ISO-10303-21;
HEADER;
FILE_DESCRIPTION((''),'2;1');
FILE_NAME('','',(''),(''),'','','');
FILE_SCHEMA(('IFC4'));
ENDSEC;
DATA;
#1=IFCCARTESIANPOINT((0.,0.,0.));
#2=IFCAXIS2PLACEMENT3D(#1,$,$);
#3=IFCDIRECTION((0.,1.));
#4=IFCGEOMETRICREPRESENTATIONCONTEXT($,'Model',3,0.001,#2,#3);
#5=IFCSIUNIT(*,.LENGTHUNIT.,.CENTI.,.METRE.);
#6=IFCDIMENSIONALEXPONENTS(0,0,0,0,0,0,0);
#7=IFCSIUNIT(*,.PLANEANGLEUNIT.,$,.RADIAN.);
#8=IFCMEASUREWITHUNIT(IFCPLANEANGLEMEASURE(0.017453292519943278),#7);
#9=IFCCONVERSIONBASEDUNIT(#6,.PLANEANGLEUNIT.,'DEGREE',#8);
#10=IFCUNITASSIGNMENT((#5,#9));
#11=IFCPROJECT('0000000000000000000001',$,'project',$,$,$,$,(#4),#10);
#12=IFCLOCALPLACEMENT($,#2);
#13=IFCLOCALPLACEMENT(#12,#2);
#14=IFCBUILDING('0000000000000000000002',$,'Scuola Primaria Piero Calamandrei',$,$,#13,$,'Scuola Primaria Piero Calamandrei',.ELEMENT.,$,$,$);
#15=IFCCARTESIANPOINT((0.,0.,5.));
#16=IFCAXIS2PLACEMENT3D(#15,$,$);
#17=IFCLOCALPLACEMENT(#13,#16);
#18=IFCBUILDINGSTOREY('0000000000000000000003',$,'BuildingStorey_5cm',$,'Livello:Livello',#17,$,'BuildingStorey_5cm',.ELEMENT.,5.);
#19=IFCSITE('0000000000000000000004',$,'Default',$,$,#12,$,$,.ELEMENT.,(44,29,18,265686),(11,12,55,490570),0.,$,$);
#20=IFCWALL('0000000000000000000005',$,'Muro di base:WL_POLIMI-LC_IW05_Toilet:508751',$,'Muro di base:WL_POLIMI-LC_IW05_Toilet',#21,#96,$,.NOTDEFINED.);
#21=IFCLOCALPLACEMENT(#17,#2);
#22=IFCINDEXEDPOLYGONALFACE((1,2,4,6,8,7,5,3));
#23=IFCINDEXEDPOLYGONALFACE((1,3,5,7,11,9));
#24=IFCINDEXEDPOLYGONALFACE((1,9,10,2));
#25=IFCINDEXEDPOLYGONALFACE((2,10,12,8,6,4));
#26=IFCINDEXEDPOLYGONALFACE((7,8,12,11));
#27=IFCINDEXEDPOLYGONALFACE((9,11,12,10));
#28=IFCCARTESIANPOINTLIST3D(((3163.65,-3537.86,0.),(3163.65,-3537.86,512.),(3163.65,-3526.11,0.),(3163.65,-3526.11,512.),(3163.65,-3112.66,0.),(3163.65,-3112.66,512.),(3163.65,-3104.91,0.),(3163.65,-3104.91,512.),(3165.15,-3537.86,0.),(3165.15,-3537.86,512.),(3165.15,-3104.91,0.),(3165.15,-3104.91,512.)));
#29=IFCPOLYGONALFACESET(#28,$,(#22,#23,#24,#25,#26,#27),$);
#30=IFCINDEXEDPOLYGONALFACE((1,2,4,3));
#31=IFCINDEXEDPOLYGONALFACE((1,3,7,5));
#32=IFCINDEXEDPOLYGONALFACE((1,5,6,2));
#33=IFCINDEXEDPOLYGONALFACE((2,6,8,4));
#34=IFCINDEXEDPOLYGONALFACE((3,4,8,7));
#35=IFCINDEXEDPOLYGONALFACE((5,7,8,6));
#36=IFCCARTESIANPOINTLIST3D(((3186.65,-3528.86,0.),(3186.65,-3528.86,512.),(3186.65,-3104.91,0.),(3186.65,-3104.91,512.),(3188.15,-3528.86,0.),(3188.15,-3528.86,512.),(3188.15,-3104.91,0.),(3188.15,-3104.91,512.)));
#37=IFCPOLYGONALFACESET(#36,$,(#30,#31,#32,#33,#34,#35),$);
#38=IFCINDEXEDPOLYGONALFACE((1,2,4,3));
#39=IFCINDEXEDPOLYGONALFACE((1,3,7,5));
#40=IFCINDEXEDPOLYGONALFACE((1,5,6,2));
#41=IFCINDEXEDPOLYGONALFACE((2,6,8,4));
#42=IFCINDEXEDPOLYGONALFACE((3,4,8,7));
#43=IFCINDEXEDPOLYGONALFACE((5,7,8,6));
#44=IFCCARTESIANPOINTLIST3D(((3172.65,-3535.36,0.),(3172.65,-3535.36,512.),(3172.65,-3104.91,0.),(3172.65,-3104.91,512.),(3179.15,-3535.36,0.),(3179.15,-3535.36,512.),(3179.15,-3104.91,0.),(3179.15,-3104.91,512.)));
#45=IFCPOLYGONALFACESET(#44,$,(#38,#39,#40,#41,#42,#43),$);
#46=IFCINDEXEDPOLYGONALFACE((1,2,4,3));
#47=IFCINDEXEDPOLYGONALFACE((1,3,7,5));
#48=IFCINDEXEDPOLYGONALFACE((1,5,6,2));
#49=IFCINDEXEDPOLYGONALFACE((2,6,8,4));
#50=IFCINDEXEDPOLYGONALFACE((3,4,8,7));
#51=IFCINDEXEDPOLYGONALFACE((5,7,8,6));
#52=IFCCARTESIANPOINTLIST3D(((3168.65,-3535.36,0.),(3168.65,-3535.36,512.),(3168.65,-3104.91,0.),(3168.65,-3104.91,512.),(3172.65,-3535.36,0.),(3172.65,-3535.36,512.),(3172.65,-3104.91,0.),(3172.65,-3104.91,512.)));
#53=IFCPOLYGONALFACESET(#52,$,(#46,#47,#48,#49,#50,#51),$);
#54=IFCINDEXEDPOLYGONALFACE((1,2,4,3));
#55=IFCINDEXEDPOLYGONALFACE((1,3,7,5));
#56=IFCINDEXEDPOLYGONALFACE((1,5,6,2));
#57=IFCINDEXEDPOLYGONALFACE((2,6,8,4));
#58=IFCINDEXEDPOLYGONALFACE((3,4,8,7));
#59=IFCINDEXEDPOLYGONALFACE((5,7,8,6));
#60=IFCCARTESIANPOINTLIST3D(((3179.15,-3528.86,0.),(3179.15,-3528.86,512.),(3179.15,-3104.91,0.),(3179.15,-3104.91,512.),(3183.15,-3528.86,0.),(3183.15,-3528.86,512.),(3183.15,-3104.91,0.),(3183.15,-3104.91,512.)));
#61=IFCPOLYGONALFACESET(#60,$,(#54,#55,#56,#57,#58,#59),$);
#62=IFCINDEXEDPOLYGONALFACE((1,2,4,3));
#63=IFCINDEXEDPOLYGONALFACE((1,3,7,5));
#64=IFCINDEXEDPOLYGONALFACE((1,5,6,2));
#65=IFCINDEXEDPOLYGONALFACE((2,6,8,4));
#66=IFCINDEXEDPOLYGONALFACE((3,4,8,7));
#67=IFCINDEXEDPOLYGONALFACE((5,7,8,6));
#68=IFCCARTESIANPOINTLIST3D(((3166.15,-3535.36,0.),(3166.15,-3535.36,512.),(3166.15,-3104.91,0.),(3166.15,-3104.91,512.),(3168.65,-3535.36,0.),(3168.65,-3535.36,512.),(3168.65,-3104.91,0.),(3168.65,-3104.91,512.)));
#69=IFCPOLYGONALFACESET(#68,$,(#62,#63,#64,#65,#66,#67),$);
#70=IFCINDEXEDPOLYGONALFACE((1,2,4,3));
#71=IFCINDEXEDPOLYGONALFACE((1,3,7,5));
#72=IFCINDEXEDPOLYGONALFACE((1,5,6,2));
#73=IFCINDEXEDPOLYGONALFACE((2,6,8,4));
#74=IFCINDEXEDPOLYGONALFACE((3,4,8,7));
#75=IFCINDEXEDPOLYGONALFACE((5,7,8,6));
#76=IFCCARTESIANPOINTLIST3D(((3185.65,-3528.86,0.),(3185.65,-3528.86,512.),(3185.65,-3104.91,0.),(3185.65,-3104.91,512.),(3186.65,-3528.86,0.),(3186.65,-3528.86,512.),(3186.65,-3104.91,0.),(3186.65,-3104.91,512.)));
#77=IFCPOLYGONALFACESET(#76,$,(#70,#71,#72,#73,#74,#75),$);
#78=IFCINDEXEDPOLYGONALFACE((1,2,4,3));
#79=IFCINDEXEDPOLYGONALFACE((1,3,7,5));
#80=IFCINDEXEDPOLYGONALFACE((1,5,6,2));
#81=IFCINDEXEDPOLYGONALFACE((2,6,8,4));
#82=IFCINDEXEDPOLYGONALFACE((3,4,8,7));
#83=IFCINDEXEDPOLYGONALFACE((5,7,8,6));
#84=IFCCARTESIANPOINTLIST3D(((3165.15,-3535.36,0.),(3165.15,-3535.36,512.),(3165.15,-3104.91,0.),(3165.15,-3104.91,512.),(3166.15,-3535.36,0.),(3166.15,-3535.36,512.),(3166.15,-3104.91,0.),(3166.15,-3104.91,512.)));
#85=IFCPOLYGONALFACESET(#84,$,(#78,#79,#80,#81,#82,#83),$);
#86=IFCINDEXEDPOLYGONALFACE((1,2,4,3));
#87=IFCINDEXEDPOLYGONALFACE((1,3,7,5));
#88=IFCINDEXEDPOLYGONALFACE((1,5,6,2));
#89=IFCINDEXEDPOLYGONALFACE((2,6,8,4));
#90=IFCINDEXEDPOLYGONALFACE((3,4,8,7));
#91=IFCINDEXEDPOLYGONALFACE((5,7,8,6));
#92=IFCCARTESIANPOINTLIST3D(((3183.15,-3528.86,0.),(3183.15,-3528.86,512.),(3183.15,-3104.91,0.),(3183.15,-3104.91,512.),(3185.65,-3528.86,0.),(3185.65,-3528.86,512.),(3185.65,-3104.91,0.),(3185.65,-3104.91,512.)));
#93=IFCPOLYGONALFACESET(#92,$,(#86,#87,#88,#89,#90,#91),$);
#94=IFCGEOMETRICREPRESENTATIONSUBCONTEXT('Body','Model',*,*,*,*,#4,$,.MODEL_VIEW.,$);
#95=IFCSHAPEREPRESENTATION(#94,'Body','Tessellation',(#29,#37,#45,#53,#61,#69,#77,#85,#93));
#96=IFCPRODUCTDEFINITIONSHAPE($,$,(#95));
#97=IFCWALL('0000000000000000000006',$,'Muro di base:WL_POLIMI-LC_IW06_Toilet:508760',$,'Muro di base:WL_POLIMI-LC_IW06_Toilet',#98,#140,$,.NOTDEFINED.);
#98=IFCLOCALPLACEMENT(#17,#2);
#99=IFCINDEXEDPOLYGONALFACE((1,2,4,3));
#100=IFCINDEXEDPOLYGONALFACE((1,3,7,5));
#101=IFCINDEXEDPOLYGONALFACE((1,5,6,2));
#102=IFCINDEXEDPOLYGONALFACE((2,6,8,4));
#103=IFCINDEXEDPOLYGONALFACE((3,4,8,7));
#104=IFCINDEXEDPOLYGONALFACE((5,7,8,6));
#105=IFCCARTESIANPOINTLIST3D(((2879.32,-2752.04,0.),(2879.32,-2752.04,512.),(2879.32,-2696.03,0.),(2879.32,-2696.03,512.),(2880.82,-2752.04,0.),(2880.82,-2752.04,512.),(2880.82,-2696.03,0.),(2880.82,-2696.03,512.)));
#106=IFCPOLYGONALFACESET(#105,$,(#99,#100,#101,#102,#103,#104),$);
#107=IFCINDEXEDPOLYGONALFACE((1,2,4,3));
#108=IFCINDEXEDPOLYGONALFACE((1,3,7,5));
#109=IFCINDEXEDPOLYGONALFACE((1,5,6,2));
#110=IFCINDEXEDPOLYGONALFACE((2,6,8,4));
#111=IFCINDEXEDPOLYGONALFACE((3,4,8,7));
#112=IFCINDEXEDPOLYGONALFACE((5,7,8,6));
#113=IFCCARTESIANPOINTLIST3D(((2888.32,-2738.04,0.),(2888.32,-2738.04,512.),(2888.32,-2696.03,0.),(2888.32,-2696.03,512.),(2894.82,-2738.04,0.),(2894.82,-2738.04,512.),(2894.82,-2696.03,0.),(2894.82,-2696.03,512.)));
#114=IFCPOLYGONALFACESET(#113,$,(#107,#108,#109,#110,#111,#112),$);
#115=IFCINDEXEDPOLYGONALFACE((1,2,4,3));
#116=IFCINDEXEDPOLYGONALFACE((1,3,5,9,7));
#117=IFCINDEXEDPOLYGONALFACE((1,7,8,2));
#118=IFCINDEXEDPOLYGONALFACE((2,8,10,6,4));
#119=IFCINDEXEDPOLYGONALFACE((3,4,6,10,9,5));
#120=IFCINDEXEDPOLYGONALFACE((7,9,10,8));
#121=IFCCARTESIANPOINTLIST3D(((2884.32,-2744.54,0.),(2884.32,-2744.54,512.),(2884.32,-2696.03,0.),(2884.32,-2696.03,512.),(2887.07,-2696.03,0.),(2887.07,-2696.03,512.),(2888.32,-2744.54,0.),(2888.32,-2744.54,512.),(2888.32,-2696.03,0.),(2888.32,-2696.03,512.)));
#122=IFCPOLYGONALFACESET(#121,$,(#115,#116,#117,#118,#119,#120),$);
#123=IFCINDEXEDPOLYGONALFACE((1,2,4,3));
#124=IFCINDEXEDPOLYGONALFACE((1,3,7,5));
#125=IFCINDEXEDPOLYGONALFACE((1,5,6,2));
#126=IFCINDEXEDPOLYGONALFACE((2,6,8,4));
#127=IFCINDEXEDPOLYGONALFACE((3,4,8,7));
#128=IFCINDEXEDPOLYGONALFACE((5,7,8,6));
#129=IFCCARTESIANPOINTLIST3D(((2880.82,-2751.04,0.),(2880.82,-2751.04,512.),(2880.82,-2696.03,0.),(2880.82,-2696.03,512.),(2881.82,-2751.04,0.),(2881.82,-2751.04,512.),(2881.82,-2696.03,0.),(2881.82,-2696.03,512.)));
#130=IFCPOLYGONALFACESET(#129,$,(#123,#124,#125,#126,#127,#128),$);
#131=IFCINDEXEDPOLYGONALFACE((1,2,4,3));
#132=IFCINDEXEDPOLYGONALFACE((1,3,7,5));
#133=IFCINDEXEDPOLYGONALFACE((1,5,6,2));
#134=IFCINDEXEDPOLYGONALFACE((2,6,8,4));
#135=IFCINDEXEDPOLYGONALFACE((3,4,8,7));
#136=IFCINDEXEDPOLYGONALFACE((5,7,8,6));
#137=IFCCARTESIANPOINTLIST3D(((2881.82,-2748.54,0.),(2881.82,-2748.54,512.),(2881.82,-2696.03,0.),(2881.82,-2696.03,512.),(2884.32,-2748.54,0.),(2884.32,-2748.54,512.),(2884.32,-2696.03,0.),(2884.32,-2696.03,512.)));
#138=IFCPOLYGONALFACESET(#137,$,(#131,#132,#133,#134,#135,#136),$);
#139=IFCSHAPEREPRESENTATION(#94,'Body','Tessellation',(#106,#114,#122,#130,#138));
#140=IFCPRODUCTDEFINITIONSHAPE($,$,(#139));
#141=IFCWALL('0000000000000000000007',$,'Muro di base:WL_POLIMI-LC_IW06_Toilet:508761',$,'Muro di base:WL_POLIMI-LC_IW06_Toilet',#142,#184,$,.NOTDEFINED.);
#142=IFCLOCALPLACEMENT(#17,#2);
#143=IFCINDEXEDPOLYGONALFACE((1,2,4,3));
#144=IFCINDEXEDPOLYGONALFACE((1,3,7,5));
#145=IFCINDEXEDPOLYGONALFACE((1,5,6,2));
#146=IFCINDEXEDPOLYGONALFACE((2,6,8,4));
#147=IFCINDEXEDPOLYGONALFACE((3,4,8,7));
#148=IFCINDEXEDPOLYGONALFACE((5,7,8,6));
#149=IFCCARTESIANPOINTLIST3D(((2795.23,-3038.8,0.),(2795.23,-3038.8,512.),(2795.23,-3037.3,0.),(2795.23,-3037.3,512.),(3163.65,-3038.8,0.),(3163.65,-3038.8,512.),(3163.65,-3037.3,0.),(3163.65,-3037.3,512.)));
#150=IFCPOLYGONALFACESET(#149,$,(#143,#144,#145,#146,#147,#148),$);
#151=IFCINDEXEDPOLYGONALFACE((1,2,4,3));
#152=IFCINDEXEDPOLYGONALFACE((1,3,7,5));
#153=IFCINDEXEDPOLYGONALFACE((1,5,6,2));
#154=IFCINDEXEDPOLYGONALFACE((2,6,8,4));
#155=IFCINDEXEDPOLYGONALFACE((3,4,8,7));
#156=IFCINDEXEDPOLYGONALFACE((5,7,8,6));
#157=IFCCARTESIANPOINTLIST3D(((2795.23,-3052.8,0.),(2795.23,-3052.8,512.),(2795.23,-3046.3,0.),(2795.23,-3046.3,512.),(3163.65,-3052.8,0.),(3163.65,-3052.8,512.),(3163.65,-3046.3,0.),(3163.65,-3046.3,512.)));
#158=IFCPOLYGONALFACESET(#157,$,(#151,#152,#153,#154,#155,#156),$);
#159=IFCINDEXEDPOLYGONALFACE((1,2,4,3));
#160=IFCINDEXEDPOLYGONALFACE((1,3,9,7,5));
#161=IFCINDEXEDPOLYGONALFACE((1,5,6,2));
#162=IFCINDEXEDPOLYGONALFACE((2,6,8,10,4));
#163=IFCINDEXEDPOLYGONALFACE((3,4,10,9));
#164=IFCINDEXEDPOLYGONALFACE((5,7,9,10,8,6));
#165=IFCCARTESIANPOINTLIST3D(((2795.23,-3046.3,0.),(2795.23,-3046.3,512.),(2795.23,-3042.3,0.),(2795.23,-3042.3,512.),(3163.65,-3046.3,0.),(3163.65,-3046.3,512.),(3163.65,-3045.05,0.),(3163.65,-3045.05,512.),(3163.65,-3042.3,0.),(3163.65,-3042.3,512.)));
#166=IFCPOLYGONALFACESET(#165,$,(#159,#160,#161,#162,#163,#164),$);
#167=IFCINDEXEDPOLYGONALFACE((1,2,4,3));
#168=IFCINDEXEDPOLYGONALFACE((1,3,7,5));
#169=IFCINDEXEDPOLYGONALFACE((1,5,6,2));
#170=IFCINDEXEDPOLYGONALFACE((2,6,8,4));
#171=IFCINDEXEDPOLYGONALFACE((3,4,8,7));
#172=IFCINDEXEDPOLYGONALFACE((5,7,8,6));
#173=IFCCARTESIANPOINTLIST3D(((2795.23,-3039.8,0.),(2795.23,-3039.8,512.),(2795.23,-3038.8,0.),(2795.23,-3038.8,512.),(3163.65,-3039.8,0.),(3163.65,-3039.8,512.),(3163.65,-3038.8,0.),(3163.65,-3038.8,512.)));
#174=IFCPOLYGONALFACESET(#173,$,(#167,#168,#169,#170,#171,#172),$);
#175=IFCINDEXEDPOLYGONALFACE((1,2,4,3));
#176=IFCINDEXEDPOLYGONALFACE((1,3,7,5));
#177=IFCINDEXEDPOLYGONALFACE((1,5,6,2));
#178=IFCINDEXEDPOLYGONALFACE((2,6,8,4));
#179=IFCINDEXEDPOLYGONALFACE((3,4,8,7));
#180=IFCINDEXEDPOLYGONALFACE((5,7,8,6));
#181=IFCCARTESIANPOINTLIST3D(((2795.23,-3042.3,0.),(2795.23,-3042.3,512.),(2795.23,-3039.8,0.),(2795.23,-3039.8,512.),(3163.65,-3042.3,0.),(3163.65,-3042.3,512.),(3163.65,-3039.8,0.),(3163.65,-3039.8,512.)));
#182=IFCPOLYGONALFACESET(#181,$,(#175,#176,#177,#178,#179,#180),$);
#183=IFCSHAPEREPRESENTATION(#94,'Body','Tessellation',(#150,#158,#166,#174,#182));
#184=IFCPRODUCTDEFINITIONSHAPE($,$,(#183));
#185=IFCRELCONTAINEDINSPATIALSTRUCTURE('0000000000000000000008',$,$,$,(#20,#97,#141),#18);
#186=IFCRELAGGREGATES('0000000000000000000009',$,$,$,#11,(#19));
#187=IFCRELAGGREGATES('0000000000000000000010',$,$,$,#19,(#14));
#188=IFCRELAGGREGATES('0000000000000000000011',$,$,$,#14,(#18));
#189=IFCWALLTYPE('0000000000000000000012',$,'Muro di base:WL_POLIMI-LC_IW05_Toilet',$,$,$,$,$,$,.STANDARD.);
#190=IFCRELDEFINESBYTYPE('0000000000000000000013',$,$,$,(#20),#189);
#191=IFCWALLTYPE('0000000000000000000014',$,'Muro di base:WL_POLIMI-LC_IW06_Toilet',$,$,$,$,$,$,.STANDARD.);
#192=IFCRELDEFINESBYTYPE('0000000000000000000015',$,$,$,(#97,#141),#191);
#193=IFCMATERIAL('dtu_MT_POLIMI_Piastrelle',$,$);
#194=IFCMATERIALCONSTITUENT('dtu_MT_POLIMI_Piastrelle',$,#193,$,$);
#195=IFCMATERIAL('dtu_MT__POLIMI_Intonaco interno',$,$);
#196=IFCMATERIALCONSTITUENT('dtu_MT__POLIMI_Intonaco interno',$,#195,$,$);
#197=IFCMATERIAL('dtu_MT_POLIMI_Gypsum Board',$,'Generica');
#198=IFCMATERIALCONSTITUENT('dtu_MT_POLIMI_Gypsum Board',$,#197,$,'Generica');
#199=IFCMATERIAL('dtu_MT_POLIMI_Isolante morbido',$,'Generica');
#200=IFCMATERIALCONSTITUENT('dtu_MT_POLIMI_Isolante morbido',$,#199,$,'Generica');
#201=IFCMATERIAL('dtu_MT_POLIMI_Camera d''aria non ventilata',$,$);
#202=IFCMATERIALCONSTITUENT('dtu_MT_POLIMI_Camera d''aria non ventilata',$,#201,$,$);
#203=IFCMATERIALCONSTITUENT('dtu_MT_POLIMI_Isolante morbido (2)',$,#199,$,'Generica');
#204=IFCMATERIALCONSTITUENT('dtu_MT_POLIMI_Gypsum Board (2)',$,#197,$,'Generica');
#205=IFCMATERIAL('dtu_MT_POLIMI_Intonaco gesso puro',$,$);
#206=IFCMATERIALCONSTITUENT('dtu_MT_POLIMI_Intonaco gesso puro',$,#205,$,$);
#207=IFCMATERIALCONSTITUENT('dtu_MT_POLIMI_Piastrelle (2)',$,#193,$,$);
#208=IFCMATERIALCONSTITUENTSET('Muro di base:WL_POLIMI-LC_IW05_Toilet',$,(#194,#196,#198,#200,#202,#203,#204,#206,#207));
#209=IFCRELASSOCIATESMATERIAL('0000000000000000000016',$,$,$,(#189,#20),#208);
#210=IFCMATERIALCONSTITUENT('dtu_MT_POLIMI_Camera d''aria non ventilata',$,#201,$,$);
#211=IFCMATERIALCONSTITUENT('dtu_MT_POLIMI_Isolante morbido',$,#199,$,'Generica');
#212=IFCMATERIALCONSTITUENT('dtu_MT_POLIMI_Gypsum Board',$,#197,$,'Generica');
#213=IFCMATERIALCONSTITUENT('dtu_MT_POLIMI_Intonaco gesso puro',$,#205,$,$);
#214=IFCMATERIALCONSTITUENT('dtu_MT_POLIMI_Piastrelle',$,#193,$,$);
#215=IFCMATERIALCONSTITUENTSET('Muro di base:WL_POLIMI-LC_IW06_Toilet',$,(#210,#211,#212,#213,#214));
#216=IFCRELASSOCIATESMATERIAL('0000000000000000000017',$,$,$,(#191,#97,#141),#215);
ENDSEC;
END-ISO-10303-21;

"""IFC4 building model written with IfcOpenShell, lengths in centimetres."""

from ifc_helpers import new_model, entity, si_unit, converted_unit, direction, frame, origin, place, context, subcontext, project, spatial, indexed_curve, outline, extrude, material, constituent, constituent_set, type_object, element, save


model = new_model("IFC4")

# Units and contexts
model_context = context("Model", 3, precision=0.001, world=origin(), true_north=direction((0.0, 1.0)))
body_context = subcontext(model_context, "Body", "Model", "MODEL_VIEW")
ifc_project = project(units=[si_unit("LENGTHUNIT", "METRE", prefix="CENTI"), converted_unit("PLANEANGLEUNIT", "DEGREE", entity("IfcPlaneAngleMeasure", 0.017453292519943278), si_unit("PLANEANGLEUNIT", "RADIAN"), dimensions=[0, 0, 0, 0, 0, 0, 0])], contexts=[model_context])

# Site, building, storey
site_placement = place(None, origin())
site = spatial("IfcSite", under=ifc_project, at=site_placement, Name="Default", CompositionType="ELEMENT", RefLatitude=(44, 29, 18, 265686), RefLongitude=(11, 12, 55, 490570), RefElevation=0.0)
building_placement = place(site_placement, origin())
building = spatial("IfcBuilding", under=site, at=building_placement, Name="Scuola Primaria Piero Calamandrei", LongName="Scuola Primaria Piero Calamandrei", CompositionType="ELEMENT")
storey_placement = place(building_placement, frame((0.0, 0.0, 5.0)))
storey = spatial("IfcBuildingStorey", under=building, at=storey_placement, Name="BuildingStorey_5cm", ObjectType="Livello:Livello", LongName="BuildingStorey_5cm", CompositionType="ELEMENT", Elevation=5.0)

# Shared definitions
ifc_material_1 = material(Name="dtu_MT_POLIMI_Intonaco gesso puro")

# Shared definitions
ifc_material_2 = material(Name="dtu_MT_POLIMI_Isolante morbido", Category="Generica")
ifc_material_3 = material(Name="dtu_MT_POLIMI_Gypsum Board", Category="Generica")
ifc_material_4 = material(Name="dtu_MT__POLIMI_Intonaco interno")
ifc_material_5 = material(Name="dtu_MT_POLIMI_Camera d'aria non ventilata")

# Walls
ifc_material_6 = material(Name="dtu_MT_POLIMI_Piastrelle")
ifc_constituent_1 = constituent(ifc_material_6, Name="dtu_MT_POLIMI_Piastrelle")
ifc_constituent_2 = constituent(ifc_material_4, Name="dtu_MT__POLIMI_Intonaco interno")
ifc_constituent_3 = constituent(ifc_material_3, Name="dtu_MT_POLIMI_Gypsum Board", Category="Generica")
ifc_constituent_4 = constituent(ifc_material_2, Name="dtu_MT_POLIMI_Isolante morbido", Category="Generica")
ifc_constituent_5 = constituent(ifc_material_5, Name="dtu_MT_POLIMI_Camera d'aria non ventilata")
ifc_constituent_6 = constituent(ifc_material_2, Name="dtu_MT_POLIMI_Isolante morbido (2)", Category="Generica")
ifc_constituent_7 = constituent(ifc_material_3, Name="dtu_MT_POLIMI_Gypsum Board (2)", Category="Generica")
ifc_constituent_8 = constituent(ifc_material_1, Name="dtu_MT_POLIMI_Intonaco gesso puro")
ifc_constituent_9 = constituent(ifc_material_6, Name="dtu_MT_POLIMI_Piastrelle (2)")
ifc_constituent_set_1 = constituent_set(constituents=[ifc_constituent_1, ifc_constituent_2, ifc_constituent_3, ifc_constituent_4, ifc_constituent_5, ifc_constituent_6, ifc_constituent_7, ifc_constituent_8, ifc_constituent_9], Name="Muro di base:WL_POLIMI-LC_IW05_Toilet")
wall_type_1 = type_object("IfcWallType", Name="Muro di base:WL_POLIMI-LC_IW05_Toilet", PredefinedType="STANDARD", material=ifc_constituent_set_1)
wall_1_placement = place(storey_placement, frame((3175.9, -3528.86, 0.0), z_axis=(0.0, 0.0, 1.0), x_axis=(0.0, 1.0, 0.0)))
element("IfcWall", 1, at=wall_1_placement, inside=storey, type_object=wall_type_1, material=ifc_constituent_set_1, Name="Muro di base:WL_POLIMI-LC_IW05_Toilet:508751", ObjectType="Muro di base:WL_POLIMI-LC_IW05_Toilet", PredefinedType="NOTDEFINED", context=body_context, shape_type="SweptSolid", body=[
    extrude(outline(indexed_curve([(-208.06, -0.5), (205.39, -0.5), (217.14, -0.5), (217.14, 1.0), (-215.81, 1.0), (-215.81, -0.5), (-208.06, -0.5)], self_intersect=False)), frame((208.14, 11.75, 0.0), z_axis=(0.0, 0.0, 1.0), x_axis=(-1.0, 0.0, 0.0)), (0.0, 0.0, 1.0), 512.0),
    extrude(outline(indexed_curve([(-0.75, -211.97), (0.75, -211.97), (0.75, 211.97), (-0.75, 211.97), (-0.75, -211.97)], self_intersect=False)), frame((211.97, -11.5, 0.0), z_axis=(0.0, 0.0, 1.0), x_axis=(0.0, 1.0, 0.0)), (0.0, 0.0, 1.0), 512.0),
    extrude(outline(indexed_curve([(-215.22, -3.25), (215.22, -3.25), (215.22, 3.25), (-215.22, 3.25), (-215.22, -3.25)], self_intersect=False)), frame((208.72, 0.0, 0.0)), (0.0, 0.0, 1.0), 512.0),
    extrude(outline(indexed_curve([(-215.22, -2.0), (215.22, -2.0), (215.22, 2.0), (-215.22, 2.0), (-215.22, -2.0)], self_intersect=False)), frame((208.72, 5.25, 0.0)), (0.0, 0.0, 1.0), 512.0),
    extrude(outline(indexed_curve([(-211.97, -2.0), (211.97, -2.0), (211.97, 2.0), (-211.97, 2.0), (-211.97, -2.0)], self_intersect=False)), frame((211.97, -5.25, 0.0)), (0.0, 0.0, 1.0), 512.0),
    extrude(outline(indexed_curve([(-215.22, -1.25), (215.22, -1.25), (215.22, 1.25), (-215.22, 1.25), (-215.22, -1.25)], self_intersect=False)), frame((208.72, 8.5, 0.0)), (0.0, 0.0, 1.0), 512.0),
    extrude(outline(indexed_curve([(-211.97, -0.5), (211.97, -0.5), (211.97, 0.5), (-211.97, 0.5), (-211.97, -0.5)], self_intersect=False)), frame((211.97, -10.25, 0.0)), (0.0, 0.0, 1.0), 512.0),
    extrude(outline(indexed_curve([(-215.22, -0.5), (215.22, -0.5), (215.22, 0.5), (-215.22, 0.5), (-215.22, -0.5)], self_intersect=False)), frame((208.72, 10.25, 0.0)), (0.0, 0.0, 1.0), 512.0),
    extrude(outline(indexed_curve([(-211.97, -1.25), (211.97, -1.25), (211.97, 1.25), (-211.97, 1.25), (-211.97, -1.25)], self_intersect=False)), frame((211.97, -8.5, 0.0)), (0.0, 0.0, 1.0), 512.0),
])
ifc_constituent_10 = constituent(ifc_material_5, Name="dtu_MT_POLIMI_Camera d'aria non ventilata")
ifc_constituent_11 = constituent(ifc_material_2, Name="dtu_MT_POLIMI_Isolante morbido", Category="Generica")
ifc_constituent_12 = constituent(ifc_material_3, Name="dtu_MT_POLIMI_Gypsum Board", Category="Generica")
ifc_constituent_13 = constituent(ifc_material_1, Name="dtu_MT_POLIMI_Intonaco gesso puro")
ifc_constituent_14 = constituent(ifc_material_6, Name="dtu_MT_POLIMI_Piastrelle")
ifc_constituent_set_2 = constituent_set(constituents=[ifc_constituent_10, ifc_constituent_11, ifc_constituent_12, ifc_constituent_13, ifc_constituent_14], Name="Muro di base:WL_POLIMI-LC_IW06_Toilet")
wall_type_2 = type_object("IfcWallType", Name="Muro di base:WL_POLIMI-LC_IW06_Toilet", PredefinedType="STANDARD", material=ifc_constituent_set_2)
wall_2_placement = place(storey_placement, frame((2887.07, -2696.03, 0.0), z_axis=(0.0, 0.0, 1.0), x_axis=(0.0, -1.0, 0.0)))
element("IfcWall", 2, at=wall_2_placement, inside=storey, type_object=wall_type_2, material=ifc_constituent_set_2, Name="Muro di base:WL_POLIMI-LC_IW06_Toilet:508760", ObjectType="Muro di base:WL_POLIMI-LC_IW06_Toilet", PredefinedType="NOTDEFINED", context=body_context, shape_type="SweptSolid", body=[
    extrude(outline(indexed_curve([(-0.75, -28.0), (0.75, -28.0), (0.75, 28.0), (-0.75, 28.0), (-0.75, -28.0)], self_intersect=False)), frame((28.0, -7.0, 0.0), z_axis=(0.0, 0.0, 1.0), x_axis=(0.0, 1.0, 0.0)), (0.0, 0.0, 1.0), 512.0),
    extrude(outline(indexed_curve([(-3.25, -21.0), (3.25, -21.0), (3.25, 21.0), (-3.25, 21.0), (-3.25, -21.0)], self_intersect=False)), frame((21.0, 4.5, 0.0), z_axis=(0.0, 0.0, 1.0), x_axis=(0.0, -1.0, 0.0)), (0.0, 0.0, 1.0), 512.0),
    extrude(outline(indexed_curve([(-19.4, -2.15), (29.1, -2.15), (29.1, 1.85), (-19.4, 1.85), (-19.4, 0.6), (-19.4, -2.15)], self_intersect=False)), frame((19.4, -0.6, 0.0)), (0.0, 0.0, 1.0), 512.0),
    extrude(outline(indexed_curve([(-27.5, -0.5), (27.5, -0.5), (27.5, 0.5), (-27.5, 0.5), (-27.5, -0.5)], self_intersect=False)), frame((27.5, -5.75, 0.0)), (0.0, 0.0, 1.0), 512.0),
    extrude(outline(indexed_curve([(-26.25, -1.25), (26.25, -1.25), (26.25, 1.25), (-26.25, 1.25), (-26.25, -1.25)], self_intersect=False)), frame((26.25, -4.0, 0.0)), (0.0, 0.0, 1.0), 512.0),
])
wall_3_placement = place(storey_placement, frame((3163.65, -3045.05, 0.0), z_axis=(0.0, 0.0, 1.0), x_axis=(-1.0, 0.0, 0.0)))
element("IfcWall", 3, at=wall_3_placement, inside=storey, type_object=wall_type_2, material=ifc_constituent_set_2, Name="Muro di base:WL_POLIMI-LC_IW06_Toilet:508761", ObjectType="Muro di base:WL_POLIMI-LC_IW06_Toilet", PredefinedType="NOTDEFINED", context=body_context, shape_type="SweptSolid", body=[
    extrude(outline(indexed_curve([(-0.75, -184.21), (0.75, -184.21), (0.75, 184.21), (-0.75, 184.21), (-0.75, -184.21)], self_intersect=False)), frame((184.21, -7.0, 0.0), z_axis=(0.0, 0.0, 1.0), x_axis=(0.0, 1.0, 0.0)), (0.0, 0.0, 1.0), 512.0),
    extrude(outline(indexed_curve([(-3.25, -184.21), (3.25, -184.21), (3.25, 184.21), (-3.25, 184.21), (-3.25, -184.21)], self_intersect=False)), frame((184.21, 4.5, 0.0), z_axis=(0.0, 0.0, 1.0), x_axis=(0.0, -1.0, 0.0)), (0.0, 0.0, 1.0), 512.0),
    extrude(outline(indexed_curve([(-147.37, -2.15), (221.05, -2.15), (221.05, 1.85), (-147.37, 1.85), (-147.37, 0.6), (-147.37, -2.15)], self_intersect=False)), frame((147.37, -0.6, 0.0)), (0.0, 0.0, 1.0), 512.0),
    extrude(outline(indexed_curve([(-184.21, -0.5), (184.21, -0.5), (184.21, 0.5), (-184.21, 0.5), (-184.21, -0.5)], self_intersect=False)), frame((184.21, -5.75, 0.0)), (0.0, 0.0, 1.0), 512.0),
    extrude(outline(indexed_curve([(-184.21, -1.25), (184.21, -1.25), (184.21, 1.25), (-184.21, 1.25), (-184.21, -1.25)], self_intersect=False)), frame((184.21, -4.0, 0.0)), (0.0, 0.0, 1.0), 512.0),
])

save(model, "model.ifc")
